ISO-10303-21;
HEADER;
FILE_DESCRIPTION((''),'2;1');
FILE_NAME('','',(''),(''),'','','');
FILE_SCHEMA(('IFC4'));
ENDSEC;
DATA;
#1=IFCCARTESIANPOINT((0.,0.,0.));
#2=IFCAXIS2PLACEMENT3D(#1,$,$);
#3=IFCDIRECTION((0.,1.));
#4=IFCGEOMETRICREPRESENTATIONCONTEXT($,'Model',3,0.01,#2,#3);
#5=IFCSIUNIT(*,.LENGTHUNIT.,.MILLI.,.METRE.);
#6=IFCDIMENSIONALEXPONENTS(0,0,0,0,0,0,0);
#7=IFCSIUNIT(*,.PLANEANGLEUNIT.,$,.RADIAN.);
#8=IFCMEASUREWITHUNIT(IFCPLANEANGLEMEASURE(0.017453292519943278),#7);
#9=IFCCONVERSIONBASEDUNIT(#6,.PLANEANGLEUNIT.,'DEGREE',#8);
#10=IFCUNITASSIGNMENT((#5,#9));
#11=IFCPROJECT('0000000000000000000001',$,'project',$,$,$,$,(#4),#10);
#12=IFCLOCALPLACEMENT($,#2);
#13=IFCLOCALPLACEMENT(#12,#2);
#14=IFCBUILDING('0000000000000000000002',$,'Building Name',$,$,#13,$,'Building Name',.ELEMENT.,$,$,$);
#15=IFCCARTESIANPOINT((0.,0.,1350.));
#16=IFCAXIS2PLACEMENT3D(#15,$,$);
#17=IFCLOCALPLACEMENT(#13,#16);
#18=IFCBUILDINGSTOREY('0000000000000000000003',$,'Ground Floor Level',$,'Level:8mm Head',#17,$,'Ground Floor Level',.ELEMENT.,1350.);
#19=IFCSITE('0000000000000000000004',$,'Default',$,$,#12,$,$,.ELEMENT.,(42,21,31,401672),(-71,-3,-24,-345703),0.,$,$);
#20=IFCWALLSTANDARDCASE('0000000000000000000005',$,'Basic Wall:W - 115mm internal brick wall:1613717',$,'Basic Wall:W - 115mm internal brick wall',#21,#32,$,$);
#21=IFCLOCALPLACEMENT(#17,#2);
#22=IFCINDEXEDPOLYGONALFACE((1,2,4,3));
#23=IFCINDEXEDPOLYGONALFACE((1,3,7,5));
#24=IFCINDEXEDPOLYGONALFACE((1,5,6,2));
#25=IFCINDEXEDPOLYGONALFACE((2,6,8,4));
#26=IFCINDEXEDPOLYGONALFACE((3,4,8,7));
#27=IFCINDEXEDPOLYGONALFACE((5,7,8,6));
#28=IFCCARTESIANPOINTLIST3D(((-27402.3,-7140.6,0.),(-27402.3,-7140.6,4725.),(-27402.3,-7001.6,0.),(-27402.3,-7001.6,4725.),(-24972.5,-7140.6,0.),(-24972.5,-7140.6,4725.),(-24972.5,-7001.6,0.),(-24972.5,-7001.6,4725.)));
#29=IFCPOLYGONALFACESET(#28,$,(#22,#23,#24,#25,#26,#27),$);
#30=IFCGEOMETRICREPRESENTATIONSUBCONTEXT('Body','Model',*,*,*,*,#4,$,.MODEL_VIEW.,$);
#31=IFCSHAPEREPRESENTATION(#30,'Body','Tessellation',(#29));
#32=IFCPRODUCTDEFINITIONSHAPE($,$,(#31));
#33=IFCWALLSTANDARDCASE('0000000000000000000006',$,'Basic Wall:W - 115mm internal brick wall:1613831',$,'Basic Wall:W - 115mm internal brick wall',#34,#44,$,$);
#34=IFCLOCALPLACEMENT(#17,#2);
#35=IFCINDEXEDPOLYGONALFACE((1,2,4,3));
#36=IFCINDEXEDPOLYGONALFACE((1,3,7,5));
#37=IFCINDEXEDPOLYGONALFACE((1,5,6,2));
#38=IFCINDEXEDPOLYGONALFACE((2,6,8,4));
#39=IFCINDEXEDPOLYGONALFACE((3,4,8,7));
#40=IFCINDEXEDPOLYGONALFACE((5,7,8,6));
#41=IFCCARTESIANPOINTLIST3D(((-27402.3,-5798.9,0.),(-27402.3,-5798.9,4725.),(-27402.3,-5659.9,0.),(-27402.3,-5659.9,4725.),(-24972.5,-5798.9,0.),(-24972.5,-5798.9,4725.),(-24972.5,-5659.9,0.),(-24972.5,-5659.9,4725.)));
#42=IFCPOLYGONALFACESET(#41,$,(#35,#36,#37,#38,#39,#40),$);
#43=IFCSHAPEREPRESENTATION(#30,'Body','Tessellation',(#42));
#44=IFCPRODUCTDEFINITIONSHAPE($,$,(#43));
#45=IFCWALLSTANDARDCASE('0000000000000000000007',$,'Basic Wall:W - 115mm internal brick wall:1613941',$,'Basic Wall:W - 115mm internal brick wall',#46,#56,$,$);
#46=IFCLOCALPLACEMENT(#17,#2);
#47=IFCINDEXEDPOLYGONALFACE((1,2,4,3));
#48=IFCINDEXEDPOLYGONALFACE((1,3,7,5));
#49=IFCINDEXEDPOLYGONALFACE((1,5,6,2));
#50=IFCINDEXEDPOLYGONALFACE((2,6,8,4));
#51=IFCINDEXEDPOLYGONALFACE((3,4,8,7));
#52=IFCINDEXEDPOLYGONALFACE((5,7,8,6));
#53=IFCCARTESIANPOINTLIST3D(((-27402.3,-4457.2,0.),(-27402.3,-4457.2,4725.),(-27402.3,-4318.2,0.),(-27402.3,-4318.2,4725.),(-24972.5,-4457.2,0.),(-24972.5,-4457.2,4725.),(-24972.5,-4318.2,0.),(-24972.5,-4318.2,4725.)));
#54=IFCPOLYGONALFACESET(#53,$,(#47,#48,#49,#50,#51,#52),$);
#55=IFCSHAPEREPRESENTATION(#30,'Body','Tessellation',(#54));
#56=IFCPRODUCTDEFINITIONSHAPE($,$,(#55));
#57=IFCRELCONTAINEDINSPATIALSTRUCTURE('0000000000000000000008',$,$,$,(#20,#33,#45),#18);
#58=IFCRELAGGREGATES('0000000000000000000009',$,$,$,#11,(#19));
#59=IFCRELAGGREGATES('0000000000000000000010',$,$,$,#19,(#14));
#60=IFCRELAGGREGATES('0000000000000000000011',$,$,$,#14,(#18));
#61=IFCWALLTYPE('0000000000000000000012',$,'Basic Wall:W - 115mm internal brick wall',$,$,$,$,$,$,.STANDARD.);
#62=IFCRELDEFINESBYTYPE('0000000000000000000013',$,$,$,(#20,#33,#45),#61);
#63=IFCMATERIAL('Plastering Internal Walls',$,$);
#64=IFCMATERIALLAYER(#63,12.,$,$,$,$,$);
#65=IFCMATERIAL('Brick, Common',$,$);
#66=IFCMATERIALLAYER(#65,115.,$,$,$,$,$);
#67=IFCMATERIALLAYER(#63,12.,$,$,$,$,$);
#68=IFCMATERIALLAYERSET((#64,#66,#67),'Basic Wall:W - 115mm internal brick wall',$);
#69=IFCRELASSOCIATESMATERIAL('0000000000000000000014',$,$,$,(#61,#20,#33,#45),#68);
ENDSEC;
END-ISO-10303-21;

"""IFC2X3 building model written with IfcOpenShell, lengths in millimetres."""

from ifc_helpers import new_model, entity, si_unit, converted_unit, direction, frame, frame_2d, origin, place, context, subcontext, project, spatial, rectangle, extrude, material, layer, layer_set, layer_usage, type_object, element, save


model = new_model("IFC2X3")

# Units and contexts
model_context = context("Model", 3, precision=0.01, world=origin(), true_north=direction((0.0, 1.0)))
body_context = subcontext(model_context, "Body", "Model", "MODEL_VIEW")
ifc_project = project(units=[si_unit("LENGTHUNIT", "METRE", prefix="MILLI"), converted_unit("PLANEANGLEUNIT", "DEGREE", entity("IfcPlaneAngleMeasure", 0.017453292519943278), si_unit("PLANEANGLEUNIT", "RADIAN"), dimensions=[0, 0, 0, 0, 0, 0, 0])], contexts=[model_context])

# Site, building, storey
site_placement = place(None, origin())
site = spatial("IfcSite", under=ifc_project, at=site_placement, Name="Default", CompositionType="ELEMENT", RefLatitude=(42, 21, 31, 401672), RefLongitude=(-71, -3, -24, -345703), RefElevation=0.0)
building_placement = place(site_placement, origin())
building = spatial("IfcBuilding", under=site, at=building_placement, Name="Building Name", LongName="Building Name", CompositionType="ELEMENT")
storey_placement = place(building_placement, frame((0.0, 0.0, 1350.0)))
storey = spatial("IfcBuildingStorey", under=building, at=storey_placement, Name="Ground Floor Level", ObjectType="Level:8mm Head", LongName="Ground Floor Level", CompositionType="ELEMENT", Elevation=1350.0)

# Shared definitions
ifc_material_1 = material(Name="Brick, Common")
ifc_material_2 = material(Name="Plastering Internal Walls")

# Walls
ifc_layer_1 = layer(ifc_material_2, 12.0)
ifc_layer_2 = layer(ifc_material_1, 115.0)
ifc_layer_3 = layer(ifc_material_2, 12.0)
ifc_layer_set_1 = layer_set([ifc_layer_1, ifc_layer_2, ifc_layer_3], Name="Basic Wall:W - 115mm internal brick wall")
wall_type_1 = type_object("IfcWallType", Name="Basic Wall:W - 115mm internal brick wall", PredefinedType="STANDARD", material=ifc_layer_set_1)
ifc_layer_usage_1 = layer_usage(ifc_layer_set_1, "AXIS2", "NEGATIVE", 69.5)
wall_1_placement = place(storey_placement, frame((-24972.5, -7071.1, 0.0), z_axis=(0.0, 0.0, 1.0), x_axis=(-1.0, 0.0, 0.0)))
element("IfcWallStandardCase", 1, at=wall_1_placement, inside=storey, type_object=wall_type_1, material=ifc_layer_usage_1, Name="Basic Wall:W - 115mm internal brick wall:1613717", ObjectType="Basic Wall:W - 115mm internal brick wall", context=body_context, shape_type="SweptSolid", body=[
    extrude(rectangle(XDim=2429.8, YDim=139.0, at=frame_2d((1214.9, 0.0), x_axis=(-1.0, 0.0))), origin(), (0.0, 0.0, 1.0), 4725.0),
])
ifc_layer_usage_2 = layer_usage(ifc_layer_set_1, "AXIS2", "NEGATIVE", 69.5)
wall_2_placement = place(storey_placement, frame((-24972.5, -5729.4, 0.0), z_axis=(0.0, 0.0, 1.0), x_axis=(-1.0, 0.0, 0.0)))
element("IfcWallStandardCase", 2, at=wall_2_placement, inside=storey, type_object=wall_type_1, material=ifc_layer_usage_2, Name="Basic Wall:W - 115mm internal brick wall:1613831", ObjectType="Basic Wall:W - 115mm internal brick wall", context=body_context, shape_type="SweptSolid", body=[
    extrude(rectangle(XDim=2429.8, YDim=139.0, at=frame_2d((1214.9, 0.0), x_axis=(-1.0, 0.0))), origin(), (0.0, 0.0, 1.0), 4725.0),
])
ifc_layer_usage_3 = layer_usage(ifc_layer_set_1, "AXIS2", "NEGATIVE", 69.5)
wall_3_placement = place(storey_placement, frame((-24972.5, -4387.7, 0.0), z_axis=(0.0, 0.0, 1.0), x_axis=(-1.0, 0.0, 0.0)))
element("IfcWallStandardCase", 3, at=wall_3_placement, inside=storey, type_object=wall_type_1, material=ifc_layer_usage_3, Name="Basic Wall:W - 115mm internal brick wall:1613941", ObjectType="Basic Wall:W - 115mm internal brick wall", context=body_context, shape_type="SweptSolid", body=[
    extrude(rectangle(XDim=2429.8, YDim=139.0, at=frame_2d((1214.9, 0.0), x_axis=(-1.0, 0.0))), origin(), (0.0, 0.0, 1.0), 4725.0),
])

save(model, "model.ifc")
